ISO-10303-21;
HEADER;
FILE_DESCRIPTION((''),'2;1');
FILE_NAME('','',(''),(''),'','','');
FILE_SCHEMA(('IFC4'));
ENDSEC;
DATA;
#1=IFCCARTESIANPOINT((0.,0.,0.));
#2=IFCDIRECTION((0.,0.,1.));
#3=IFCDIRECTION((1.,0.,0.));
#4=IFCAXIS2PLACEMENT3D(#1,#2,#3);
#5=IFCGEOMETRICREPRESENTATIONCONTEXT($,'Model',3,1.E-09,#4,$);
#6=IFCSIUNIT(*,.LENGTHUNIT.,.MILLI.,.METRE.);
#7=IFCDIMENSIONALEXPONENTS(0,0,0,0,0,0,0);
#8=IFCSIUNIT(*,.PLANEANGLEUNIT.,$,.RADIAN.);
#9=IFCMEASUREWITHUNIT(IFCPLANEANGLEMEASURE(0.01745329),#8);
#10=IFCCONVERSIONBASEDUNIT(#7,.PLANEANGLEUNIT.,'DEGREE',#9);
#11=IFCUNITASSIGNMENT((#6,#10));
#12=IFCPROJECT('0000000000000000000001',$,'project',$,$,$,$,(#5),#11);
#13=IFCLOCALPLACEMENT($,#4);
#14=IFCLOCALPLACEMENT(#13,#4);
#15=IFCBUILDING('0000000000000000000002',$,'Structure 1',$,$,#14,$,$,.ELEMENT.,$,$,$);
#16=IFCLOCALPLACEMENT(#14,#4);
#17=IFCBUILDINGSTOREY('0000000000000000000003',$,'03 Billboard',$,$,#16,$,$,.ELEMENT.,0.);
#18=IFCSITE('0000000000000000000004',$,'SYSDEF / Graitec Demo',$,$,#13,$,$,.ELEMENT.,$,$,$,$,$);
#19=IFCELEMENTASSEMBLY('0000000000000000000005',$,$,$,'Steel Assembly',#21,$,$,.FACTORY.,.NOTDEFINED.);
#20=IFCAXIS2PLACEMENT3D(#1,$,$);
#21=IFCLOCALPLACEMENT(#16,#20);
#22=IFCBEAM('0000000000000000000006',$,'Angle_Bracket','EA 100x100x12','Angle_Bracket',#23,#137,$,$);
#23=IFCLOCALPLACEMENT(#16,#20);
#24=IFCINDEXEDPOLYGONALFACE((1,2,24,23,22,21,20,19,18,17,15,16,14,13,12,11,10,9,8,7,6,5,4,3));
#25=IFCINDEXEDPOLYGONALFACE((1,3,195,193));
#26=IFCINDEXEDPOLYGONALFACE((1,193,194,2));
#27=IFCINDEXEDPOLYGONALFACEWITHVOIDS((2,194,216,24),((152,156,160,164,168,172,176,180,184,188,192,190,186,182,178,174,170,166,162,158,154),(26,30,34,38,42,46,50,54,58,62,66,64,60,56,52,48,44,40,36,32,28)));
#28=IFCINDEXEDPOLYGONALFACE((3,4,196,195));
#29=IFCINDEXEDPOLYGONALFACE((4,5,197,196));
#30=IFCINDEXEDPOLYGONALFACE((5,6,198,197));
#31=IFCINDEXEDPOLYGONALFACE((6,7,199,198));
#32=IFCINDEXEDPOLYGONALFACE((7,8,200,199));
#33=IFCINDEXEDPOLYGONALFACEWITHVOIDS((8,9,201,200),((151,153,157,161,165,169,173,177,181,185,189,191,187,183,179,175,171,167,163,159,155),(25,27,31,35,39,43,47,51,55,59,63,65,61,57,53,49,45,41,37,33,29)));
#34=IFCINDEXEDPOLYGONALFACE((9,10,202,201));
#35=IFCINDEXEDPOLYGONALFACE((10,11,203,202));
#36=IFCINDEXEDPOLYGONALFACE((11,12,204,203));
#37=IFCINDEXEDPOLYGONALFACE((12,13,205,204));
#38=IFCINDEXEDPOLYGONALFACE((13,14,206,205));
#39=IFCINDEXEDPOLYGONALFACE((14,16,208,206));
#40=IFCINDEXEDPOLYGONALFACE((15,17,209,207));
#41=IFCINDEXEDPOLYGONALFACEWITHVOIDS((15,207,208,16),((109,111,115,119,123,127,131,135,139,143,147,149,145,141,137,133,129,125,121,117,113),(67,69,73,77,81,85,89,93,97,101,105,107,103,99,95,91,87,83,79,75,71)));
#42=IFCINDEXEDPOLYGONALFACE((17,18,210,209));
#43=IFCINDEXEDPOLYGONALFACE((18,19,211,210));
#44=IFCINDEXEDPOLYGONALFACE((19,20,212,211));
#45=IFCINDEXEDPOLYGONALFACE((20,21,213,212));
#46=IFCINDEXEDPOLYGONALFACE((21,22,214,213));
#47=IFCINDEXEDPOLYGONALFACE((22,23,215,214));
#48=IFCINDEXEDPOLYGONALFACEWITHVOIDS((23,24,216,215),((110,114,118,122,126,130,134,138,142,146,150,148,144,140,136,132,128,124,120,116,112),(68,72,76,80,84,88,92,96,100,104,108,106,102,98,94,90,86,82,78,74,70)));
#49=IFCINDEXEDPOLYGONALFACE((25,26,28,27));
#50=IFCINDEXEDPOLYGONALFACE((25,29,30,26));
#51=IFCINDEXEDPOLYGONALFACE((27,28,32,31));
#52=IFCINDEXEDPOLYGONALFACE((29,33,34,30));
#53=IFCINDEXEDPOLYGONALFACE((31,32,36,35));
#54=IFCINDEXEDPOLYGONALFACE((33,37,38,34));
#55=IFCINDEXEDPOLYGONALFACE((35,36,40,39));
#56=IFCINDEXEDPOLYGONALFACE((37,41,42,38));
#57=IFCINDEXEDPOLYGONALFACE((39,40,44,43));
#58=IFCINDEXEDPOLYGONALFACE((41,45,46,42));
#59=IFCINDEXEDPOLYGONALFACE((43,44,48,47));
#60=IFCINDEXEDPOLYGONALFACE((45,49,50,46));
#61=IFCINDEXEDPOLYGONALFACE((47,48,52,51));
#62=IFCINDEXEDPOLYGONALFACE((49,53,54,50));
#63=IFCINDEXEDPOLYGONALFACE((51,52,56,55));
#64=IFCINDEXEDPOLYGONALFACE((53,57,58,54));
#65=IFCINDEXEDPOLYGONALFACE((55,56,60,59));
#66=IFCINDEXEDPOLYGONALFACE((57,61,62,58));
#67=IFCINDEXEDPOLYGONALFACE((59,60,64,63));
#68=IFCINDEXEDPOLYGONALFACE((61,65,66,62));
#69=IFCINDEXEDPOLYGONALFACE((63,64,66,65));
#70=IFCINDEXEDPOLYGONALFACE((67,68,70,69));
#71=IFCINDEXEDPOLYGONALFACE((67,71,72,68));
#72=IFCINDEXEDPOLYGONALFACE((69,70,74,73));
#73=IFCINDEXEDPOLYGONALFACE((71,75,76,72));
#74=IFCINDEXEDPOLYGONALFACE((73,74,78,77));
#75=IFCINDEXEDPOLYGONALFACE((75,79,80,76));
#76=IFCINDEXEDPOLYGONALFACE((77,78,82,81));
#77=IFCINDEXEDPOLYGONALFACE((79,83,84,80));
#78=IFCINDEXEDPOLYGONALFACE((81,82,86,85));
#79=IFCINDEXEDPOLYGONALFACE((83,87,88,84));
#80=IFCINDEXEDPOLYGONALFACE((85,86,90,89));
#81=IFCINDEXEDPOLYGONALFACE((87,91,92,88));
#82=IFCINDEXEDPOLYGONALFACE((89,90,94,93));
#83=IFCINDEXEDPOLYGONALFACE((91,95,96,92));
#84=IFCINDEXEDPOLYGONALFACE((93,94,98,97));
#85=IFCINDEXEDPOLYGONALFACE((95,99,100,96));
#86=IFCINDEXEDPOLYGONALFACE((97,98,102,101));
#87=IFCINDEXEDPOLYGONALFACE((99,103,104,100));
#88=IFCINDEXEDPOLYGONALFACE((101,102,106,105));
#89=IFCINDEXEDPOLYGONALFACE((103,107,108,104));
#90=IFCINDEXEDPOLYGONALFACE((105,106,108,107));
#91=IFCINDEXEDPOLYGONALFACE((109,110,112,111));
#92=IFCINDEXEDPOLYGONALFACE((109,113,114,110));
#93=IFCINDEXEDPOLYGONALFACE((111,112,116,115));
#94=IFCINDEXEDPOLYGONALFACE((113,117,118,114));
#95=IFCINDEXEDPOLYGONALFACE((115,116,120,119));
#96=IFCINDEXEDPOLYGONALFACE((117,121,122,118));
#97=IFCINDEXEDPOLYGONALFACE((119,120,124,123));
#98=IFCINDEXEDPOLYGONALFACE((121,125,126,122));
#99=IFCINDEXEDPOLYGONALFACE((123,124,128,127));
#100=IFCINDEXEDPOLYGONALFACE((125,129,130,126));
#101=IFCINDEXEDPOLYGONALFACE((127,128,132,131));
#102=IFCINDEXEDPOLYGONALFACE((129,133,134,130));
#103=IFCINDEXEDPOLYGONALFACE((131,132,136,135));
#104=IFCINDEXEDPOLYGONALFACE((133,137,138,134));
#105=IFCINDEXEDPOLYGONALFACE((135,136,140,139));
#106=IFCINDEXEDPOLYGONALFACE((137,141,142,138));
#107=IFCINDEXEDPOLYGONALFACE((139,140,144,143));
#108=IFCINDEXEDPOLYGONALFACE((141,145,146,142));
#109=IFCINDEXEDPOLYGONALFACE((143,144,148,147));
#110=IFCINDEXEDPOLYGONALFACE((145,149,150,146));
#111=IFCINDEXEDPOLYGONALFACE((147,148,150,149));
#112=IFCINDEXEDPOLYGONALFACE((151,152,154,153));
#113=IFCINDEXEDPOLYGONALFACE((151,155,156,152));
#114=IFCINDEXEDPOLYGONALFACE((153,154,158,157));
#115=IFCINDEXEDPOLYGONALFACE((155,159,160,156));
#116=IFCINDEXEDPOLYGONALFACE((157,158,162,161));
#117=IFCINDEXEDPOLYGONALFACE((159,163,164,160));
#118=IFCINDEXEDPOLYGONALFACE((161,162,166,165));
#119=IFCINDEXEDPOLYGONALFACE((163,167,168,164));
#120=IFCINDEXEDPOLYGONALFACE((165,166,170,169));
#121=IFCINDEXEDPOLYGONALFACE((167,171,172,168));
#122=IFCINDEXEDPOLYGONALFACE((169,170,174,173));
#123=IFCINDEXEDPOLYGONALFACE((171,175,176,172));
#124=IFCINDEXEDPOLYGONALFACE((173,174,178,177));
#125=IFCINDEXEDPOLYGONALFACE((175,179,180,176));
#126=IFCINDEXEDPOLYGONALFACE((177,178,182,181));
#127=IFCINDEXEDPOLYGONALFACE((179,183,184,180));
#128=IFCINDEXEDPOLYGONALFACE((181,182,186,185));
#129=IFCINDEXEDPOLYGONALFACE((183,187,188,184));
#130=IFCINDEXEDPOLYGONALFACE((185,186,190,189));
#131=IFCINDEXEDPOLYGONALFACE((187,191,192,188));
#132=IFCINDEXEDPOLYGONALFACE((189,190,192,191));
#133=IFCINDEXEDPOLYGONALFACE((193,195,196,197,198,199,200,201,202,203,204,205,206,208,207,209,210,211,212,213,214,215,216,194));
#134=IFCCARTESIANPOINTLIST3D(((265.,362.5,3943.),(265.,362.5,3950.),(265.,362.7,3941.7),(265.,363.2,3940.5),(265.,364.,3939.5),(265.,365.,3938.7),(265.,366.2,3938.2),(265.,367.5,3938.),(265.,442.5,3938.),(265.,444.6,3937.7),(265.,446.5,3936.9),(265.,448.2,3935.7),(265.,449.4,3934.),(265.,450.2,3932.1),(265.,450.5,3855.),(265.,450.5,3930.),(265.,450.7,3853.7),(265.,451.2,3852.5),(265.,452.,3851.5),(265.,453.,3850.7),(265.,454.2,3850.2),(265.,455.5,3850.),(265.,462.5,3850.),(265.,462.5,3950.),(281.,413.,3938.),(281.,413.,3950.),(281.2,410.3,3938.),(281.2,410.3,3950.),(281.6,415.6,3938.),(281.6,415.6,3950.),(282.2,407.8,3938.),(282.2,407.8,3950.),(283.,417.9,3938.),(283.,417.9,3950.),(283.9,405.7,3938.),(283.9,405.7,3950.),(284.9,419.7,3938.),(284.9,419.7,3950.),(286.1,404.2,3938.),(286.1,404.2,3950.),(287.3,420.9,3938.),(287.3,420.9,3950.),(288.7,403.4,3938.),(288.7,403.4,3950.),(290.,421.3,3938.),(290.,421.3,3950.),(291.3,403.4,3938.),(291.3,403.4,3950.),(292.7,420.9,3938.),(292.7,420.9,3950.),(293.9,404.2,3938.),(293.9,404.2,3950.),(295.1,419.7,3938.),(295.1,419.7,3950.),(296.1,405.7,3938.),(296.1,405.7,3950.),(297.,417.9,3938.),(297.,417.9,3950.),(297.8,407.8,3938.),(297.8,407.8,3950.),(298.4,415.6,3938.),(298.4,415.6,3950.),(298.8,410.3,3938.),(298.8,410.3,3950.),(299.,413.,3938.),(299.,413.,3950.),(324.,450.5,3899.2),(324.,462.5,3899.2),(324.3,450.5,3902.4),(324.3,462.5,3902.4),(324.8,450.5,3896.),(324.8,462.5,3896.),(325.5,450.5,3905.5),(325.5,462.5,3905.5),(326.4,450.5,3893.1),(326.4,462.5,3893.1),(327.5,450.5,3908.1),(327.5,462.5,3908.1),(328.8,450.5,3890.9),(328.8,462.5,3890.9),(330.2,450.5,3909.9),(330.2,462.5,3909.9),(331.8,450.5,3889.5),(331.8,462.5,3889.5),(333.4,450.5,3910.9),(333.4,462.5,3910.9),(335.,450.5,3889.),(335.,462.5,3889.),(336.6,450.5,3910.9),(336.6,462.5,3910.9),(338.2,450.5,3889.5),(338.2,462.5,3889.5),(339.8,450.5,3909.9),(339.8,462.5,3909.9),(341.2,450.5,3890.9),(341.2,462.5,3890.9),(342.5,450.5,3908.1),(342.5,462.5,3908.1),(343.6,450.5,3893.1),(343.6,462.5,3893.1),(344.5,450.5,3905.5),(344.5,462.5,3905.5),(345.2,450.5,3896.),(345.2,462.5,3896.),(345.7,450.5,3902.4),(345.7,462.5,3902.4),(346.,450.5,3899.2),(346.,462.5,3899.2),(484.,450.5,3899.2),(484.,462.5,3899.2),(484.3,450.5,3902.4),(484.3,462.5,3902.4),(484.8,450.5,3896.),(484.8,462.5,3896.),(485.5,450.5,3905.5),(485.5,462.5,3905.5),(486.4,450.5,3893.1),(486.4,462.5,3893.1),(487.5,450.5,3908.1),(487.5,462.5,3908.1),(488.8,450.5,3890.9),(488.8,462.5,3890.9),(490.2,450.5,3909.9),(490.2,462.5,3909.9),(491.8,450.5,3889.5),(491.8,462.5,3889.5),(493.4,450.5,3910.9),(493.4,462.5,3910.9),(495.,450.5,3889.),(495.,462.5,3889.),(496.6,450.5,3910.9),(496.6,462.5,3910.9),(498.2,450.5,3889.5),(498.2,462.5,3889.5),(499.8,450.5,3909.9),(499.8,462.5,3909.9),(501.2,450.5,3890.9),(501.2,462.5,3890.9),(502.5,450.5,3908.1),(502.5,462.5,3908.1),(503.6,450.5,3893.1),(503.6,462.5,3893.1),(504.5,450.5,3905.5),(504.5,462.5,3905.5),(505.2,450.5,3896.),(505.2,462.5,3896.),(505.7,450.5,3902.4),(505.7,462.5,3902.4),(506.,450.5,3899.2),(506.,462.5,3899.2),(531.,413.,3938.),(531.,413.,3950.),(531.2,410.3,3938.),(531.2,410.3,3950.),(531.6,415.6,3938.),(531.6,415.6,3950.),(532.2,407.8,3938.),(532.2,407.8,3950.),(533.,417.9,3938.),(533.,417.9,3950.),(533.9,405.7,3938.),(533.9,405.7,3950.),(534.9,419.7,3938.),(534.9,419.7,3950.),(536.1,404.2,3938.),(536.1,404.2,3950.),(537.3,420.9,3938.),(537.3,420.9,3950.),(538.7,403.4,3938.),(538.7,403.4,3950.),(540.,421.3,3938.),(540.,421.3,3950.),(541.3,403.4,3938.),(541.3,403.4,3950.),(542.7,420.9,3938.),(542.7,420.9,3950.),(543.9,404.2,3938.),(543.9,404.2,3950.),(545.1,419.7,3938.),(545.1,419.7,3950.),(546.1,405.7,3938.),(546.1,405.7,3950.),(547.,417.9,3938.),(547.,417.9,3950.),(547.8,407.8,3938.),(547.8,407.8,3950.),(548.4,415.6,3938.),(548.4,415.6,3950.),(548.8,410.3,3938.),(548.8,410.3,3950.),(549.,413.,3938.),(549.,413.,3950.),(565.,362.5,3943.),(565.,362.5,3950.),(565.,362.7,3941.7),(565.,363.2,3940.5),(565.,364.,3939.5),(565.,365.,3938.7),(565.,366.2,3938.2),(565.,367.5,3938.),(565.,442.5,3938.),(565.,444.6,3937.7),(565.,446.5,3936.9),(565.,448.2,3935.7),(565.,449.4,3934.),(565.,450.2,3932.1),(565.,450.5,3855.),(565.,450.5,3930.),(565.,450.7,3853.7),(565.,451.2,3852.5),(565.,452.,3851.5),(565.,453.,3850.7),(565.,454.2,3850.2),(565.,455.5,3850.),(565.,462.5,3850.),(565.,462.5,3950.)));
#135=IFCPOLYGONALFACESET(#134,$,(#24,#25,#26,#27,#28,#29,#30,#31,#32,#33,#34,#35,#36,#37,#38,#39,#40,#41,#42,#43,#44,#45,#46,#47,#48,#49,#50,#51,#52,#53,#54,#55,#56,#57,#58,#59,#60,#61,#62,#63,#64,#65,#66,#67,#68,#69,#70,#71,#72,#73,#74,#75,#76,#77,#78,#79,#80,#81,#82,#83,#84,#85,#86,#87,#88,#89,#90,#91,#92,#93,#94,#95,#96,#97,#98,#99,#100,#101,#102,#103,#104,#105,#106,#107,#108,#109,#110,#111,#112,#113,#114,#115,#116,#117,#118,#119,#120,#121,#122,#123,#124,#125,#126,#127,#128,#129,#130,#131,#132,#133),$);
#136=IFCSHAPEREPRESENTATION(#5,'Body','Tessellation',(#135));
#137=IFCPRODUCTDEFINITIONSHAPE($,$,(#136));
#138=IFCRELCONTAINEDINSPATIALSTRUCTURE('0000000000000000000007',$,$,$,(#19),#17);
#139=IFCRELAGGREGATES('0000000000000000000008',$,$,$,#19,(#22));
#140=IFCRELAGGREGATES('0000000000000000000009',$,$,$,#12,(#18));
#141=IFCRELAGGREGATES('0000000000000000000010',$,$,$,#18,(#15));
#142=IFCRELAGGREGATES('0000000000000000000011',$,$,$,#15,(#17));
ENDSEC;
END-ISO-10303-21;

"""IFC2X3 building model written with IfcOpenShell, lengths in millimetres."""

from ifc_helpers import new_model, entity, si_unit, converted_unit, frame, frame_2d, origin, origin_with_axes, place, context, project, spatial, circle, l_section, extrude, element, aggregate, save


model = new_model("IFC2X3")

# Units and contexts
model_context = context("Model", 3, precision=1e-09, world=origin_with_axes())
ifc_project = project(units=[si_unit("LENGTHUNIT", "METRE", prefix="MILLI"), converted_unit("PLANEANGLEUNIT", "DEGREE", entity("IfcPlaneAngleMeasure", 0.01745329), si_unit("PLANEANGLEUNIT", "RADIAN"), dimensions=[0, 0, 0, 0, 0, 0, 0])], contexts=[model_context])

# Site, building, storey
site_placement = place(None, origin_with_axes())
site = spatial("IfcSite", under=ifc_project, at=site_placement, Name="SYSDEF / Graitec Demo", CompositionType="ELEMENT")
building_placement = place(site_placement, origin_with_axes())
building = spatial("IfcBuilding", under=site, at=building_placement, Name="Structure 1", CompositionType="ELEMENT")
storey_placement = place(building_placement, origin_with_axes())
storey = spatial("IfcBuildingStorey", under=building, at=storey_placement, Name="03 Billboard", CompositionType="ELEMENT", Elevation=0.0)

# Element assembly, beam, openings
assembly_1_placement = place(None, frame((265.0, 433.3, 3920.8), z_axis=(1.0, 0.0, 0.0), x_axis=(0.0, -1.0, 0.0)))
assembly_1 = element("IfcElementAssembly", 1, at=assembly_1_placement, inside=storey, ObjectType="Steel Assembly", AssemblyPlace="FACTORY", PredefinedType="NOTDEFINED")
beam_placement = place(assembly_1_placement, origin_with_axes())
beam = element("IfcBeam", 2, at=beam_placement, Name="Angle_Bracket", Description="EA 100x100x12", ObjectType="Angle_Bracket", context=model_context, shape_type="SweptSolid", body=[
    extrude(l_section(Depth=100.0, Width=100.0, Thickness=12.0, FilletRadius=8.0, EdgeRadius=5.0, at=frame_2d((20.8, 20.8))), origin(), (0.0, 0.0, 1.0), 300.0),
])
opening_1_placement = place(beam_placement, frame((-16.7, 20.8, 219.0), z_axis=(1.0, 0.0, 0.0), x_axis=(0.0, 1.0, 0.0)))
element("IfcOpeningElement", 3, at=opening_1_placement, cuts=beam, ObjectType="Opening", context=model_context, shape_type="SweptSolid", body=[
    extrude(circle(Radius=11.0, at=frame_2d((0.0, 11.0), x_axis=(1.0, 0.0))), origin(), (0.0, 0.0, -1.0), 13.0),
])
opening_2_placement = place(beam_placement, frame((-16.7, 20.8, 59.0), z_axis=(1.0, 0.0, 0.0), x_axis=(0.0, 1.0, 0.0)))
element("IfcOpeningElement", 4, at=opening_2_placement, cuts=beam, ObjectType="Opening", context=model_context, shape_type="SweptSolid", body=[
    extrude(circle(Radius=11.0, at=frame_2d((0.0, 11.0), x_axis=(1.0, 0.0))), origin(), (0.0, 0.0, -1.0), 13.0),
])
opening_3_placement = place(beam_placement, frame((21.0, -16.7, 266.0), z_axis=(0.0, 1.0, 0.0), x_axis=(-1.0, 0.0, 0.0)))
element("IfcOpeningElement", 5, at=opening_3_placement, cuts=beam, ObjectType="Opening", context=model_context, shape_type="SweptSolid", body=[
    extrude(circle(Radius=9.0, at=frame_2d((0.0, 9.0), x_axis=(1.0, 0.0))), origin(), (0.0, 0.0, -1.0), 13.0),
])
opening_4_placement = place(beam_placement, frame((21.0, -16.7, 16.0), z_axis=(0.0, 1.0, 0.0), x_axis=(-1.0, 0.0, 0.0)))
element("IfcOpeningElement", 6, at=opening_4_placement, cuts=beam, ObjectType="Opening", context=model_context, shape_type="SweptSolid", body=[
    extrude(circle(Radius=9.0, at=frame_2d((0.0, 9.0), x_axis=(1.0, 0.0))), origin(), (0.0, 0.0, -1.0), 13.0),
])
aggregate(assembly_1, [beam])

save(model, "model.ifc")
